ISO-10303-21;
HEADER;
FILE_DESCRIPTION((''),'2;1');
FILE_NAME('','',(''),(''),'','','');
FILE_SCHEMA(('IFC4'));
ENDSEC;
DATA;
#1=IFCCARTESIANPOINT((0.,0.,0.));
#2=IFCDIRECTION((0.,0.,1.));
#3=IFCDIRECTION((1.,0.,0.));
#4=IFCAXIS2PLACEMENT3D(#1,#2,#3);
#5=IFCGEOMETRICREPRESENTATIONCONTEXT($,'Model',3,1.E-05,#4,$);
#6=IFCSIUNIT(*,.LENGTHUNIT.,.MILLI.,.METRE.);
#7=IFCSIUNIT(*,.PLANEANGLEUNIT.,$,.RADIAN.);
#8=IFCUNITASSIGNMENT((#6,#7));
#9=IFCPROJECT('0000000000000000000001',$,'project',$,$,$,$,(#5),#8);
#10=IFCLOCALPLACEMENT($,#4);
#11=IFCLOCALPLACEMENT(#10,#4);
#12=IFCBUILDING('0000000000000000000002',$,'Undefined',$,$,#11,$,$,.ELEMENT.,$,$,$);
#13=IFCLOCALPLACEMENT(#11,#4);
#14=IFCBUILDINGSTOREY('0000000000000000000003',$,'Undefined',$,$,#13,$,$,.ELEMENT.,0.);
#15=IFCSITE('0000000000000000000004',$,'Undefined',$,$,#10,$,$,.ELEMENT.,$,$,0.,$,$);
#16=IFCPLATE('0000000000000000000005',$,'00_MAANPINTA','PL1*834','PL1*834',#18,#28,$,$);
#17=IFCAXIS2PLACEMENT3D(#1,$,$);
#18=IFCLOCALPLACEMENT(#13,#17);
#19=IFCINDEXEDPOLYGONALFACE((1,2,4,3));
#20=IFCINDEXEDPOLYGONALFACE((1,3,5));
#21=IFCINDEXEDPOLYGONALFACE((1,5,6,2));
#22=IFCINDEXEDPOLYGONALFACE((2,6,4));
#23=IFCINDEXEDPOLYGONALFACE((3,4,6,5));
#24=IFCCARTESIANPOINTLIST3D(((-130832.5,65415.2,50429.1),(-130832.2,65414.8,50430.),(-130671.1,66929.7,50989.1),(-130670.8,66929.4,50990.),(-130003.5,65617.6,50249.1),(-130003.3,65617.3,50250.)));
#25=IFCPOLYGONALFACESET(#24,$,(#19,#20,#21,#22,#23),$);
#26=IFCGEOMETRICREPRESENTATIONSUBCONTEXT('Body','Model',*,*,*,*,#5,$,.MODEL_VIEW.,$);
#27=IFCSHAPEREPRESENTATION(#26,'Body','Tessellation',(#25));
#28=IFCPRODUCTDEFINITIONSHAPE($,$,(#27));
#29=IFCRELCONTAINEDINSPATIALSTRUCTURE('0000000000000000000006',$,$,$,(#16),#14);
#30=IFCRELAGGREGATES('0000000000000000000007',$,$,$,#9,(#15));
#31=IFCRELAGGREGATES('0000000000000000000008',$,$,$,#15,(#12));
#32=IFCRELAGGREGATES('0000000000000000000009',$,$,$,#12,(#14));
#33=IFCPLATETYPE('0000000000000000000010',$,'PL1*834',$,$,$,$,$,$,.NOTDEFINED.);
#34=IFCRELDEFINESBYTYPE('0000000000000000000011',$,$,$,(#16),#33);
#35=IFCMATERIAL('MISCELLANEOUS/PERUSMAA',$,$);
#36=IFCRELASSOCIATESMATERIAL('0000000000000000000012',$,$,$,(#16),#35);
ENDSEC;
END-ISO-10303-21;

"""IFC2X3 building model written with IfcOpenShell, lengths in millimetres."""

from ifc_helpers import new_model, si_unit, frame, origin_with_axes, place, context, subcontext, project, spatial, polyline, outline, extrude, material, type_object, element, save


model = new_model("IFC2X3")

# Units and contexts
model_context = context("Model", 3, precision=1e-05, world=origin_with_axes())
body_context = subcontext(model_context, "Body", "Model", "MODEL_VIEW")
ifc_project = project(units=[si_unit("LENGTHUNIT", "METRE", prefix="MILLI"), si_unit("PLANEANGLEUNIT", "RADIAN")], contexts=[model_context])

# Site, building, storey
site_placement = place(None, origin_with_axes())
site = spatial("IfcSite", under=ifc_project, at=site_placement, Name="Undefined", CompositionType="ELEMENT", RefElevation=0.0)
building_placement = place(site_placement, origin_with_axes())
building = spatial("IfcBuilding", under=site, at=building_placement, Name="Undefined", CompositionType="ELEMENT")
storey_placement = place(building_placement, origin_with_axes())
storey = spatial("IfcBuildingStorey", under=building, at=storey_placement, Name="Undefined", CompositionType="ELEMENT", Elevation=0.0)

# Plate
ifc_material = material(Name="MISCELLANEOUS/PERUSMAA")
plate_type_1 = type_object("IfcPlateType", Name="PL1*834", PredefinedType="NOTDEFINED")
plate_1_placement = place(storey_placement, frame((-130003.4, 65617.4, 50249.6), z_axis=(-0.280959, 0.359016, -0.890039), x_axis=(-0.950526, -0.232158, 0.206406)))
element("IfcPlate", 1, at=plate_1_placement, inside=storey, type_object=plate_type_1, material=ifc_material, Name="00_MAANPINTA", Description="PL1*834", ObjectType="PL1*834", context=body_context, shape_type="SweptSolid", body=[
    extrude(outline(polyline([(0.0, 0.0), (872.1, 0.0), (482.6, 1575.4), (0.0, 0.0)])), frame((0.0, 0.0, -0.5), z_axis=(0.0, 0.0, 1.0), x_axis=(1.0, 0.0, 0.0)), (0.0, 0.0, 1.0), 1.0),
])

save(model, "model.ifc")
